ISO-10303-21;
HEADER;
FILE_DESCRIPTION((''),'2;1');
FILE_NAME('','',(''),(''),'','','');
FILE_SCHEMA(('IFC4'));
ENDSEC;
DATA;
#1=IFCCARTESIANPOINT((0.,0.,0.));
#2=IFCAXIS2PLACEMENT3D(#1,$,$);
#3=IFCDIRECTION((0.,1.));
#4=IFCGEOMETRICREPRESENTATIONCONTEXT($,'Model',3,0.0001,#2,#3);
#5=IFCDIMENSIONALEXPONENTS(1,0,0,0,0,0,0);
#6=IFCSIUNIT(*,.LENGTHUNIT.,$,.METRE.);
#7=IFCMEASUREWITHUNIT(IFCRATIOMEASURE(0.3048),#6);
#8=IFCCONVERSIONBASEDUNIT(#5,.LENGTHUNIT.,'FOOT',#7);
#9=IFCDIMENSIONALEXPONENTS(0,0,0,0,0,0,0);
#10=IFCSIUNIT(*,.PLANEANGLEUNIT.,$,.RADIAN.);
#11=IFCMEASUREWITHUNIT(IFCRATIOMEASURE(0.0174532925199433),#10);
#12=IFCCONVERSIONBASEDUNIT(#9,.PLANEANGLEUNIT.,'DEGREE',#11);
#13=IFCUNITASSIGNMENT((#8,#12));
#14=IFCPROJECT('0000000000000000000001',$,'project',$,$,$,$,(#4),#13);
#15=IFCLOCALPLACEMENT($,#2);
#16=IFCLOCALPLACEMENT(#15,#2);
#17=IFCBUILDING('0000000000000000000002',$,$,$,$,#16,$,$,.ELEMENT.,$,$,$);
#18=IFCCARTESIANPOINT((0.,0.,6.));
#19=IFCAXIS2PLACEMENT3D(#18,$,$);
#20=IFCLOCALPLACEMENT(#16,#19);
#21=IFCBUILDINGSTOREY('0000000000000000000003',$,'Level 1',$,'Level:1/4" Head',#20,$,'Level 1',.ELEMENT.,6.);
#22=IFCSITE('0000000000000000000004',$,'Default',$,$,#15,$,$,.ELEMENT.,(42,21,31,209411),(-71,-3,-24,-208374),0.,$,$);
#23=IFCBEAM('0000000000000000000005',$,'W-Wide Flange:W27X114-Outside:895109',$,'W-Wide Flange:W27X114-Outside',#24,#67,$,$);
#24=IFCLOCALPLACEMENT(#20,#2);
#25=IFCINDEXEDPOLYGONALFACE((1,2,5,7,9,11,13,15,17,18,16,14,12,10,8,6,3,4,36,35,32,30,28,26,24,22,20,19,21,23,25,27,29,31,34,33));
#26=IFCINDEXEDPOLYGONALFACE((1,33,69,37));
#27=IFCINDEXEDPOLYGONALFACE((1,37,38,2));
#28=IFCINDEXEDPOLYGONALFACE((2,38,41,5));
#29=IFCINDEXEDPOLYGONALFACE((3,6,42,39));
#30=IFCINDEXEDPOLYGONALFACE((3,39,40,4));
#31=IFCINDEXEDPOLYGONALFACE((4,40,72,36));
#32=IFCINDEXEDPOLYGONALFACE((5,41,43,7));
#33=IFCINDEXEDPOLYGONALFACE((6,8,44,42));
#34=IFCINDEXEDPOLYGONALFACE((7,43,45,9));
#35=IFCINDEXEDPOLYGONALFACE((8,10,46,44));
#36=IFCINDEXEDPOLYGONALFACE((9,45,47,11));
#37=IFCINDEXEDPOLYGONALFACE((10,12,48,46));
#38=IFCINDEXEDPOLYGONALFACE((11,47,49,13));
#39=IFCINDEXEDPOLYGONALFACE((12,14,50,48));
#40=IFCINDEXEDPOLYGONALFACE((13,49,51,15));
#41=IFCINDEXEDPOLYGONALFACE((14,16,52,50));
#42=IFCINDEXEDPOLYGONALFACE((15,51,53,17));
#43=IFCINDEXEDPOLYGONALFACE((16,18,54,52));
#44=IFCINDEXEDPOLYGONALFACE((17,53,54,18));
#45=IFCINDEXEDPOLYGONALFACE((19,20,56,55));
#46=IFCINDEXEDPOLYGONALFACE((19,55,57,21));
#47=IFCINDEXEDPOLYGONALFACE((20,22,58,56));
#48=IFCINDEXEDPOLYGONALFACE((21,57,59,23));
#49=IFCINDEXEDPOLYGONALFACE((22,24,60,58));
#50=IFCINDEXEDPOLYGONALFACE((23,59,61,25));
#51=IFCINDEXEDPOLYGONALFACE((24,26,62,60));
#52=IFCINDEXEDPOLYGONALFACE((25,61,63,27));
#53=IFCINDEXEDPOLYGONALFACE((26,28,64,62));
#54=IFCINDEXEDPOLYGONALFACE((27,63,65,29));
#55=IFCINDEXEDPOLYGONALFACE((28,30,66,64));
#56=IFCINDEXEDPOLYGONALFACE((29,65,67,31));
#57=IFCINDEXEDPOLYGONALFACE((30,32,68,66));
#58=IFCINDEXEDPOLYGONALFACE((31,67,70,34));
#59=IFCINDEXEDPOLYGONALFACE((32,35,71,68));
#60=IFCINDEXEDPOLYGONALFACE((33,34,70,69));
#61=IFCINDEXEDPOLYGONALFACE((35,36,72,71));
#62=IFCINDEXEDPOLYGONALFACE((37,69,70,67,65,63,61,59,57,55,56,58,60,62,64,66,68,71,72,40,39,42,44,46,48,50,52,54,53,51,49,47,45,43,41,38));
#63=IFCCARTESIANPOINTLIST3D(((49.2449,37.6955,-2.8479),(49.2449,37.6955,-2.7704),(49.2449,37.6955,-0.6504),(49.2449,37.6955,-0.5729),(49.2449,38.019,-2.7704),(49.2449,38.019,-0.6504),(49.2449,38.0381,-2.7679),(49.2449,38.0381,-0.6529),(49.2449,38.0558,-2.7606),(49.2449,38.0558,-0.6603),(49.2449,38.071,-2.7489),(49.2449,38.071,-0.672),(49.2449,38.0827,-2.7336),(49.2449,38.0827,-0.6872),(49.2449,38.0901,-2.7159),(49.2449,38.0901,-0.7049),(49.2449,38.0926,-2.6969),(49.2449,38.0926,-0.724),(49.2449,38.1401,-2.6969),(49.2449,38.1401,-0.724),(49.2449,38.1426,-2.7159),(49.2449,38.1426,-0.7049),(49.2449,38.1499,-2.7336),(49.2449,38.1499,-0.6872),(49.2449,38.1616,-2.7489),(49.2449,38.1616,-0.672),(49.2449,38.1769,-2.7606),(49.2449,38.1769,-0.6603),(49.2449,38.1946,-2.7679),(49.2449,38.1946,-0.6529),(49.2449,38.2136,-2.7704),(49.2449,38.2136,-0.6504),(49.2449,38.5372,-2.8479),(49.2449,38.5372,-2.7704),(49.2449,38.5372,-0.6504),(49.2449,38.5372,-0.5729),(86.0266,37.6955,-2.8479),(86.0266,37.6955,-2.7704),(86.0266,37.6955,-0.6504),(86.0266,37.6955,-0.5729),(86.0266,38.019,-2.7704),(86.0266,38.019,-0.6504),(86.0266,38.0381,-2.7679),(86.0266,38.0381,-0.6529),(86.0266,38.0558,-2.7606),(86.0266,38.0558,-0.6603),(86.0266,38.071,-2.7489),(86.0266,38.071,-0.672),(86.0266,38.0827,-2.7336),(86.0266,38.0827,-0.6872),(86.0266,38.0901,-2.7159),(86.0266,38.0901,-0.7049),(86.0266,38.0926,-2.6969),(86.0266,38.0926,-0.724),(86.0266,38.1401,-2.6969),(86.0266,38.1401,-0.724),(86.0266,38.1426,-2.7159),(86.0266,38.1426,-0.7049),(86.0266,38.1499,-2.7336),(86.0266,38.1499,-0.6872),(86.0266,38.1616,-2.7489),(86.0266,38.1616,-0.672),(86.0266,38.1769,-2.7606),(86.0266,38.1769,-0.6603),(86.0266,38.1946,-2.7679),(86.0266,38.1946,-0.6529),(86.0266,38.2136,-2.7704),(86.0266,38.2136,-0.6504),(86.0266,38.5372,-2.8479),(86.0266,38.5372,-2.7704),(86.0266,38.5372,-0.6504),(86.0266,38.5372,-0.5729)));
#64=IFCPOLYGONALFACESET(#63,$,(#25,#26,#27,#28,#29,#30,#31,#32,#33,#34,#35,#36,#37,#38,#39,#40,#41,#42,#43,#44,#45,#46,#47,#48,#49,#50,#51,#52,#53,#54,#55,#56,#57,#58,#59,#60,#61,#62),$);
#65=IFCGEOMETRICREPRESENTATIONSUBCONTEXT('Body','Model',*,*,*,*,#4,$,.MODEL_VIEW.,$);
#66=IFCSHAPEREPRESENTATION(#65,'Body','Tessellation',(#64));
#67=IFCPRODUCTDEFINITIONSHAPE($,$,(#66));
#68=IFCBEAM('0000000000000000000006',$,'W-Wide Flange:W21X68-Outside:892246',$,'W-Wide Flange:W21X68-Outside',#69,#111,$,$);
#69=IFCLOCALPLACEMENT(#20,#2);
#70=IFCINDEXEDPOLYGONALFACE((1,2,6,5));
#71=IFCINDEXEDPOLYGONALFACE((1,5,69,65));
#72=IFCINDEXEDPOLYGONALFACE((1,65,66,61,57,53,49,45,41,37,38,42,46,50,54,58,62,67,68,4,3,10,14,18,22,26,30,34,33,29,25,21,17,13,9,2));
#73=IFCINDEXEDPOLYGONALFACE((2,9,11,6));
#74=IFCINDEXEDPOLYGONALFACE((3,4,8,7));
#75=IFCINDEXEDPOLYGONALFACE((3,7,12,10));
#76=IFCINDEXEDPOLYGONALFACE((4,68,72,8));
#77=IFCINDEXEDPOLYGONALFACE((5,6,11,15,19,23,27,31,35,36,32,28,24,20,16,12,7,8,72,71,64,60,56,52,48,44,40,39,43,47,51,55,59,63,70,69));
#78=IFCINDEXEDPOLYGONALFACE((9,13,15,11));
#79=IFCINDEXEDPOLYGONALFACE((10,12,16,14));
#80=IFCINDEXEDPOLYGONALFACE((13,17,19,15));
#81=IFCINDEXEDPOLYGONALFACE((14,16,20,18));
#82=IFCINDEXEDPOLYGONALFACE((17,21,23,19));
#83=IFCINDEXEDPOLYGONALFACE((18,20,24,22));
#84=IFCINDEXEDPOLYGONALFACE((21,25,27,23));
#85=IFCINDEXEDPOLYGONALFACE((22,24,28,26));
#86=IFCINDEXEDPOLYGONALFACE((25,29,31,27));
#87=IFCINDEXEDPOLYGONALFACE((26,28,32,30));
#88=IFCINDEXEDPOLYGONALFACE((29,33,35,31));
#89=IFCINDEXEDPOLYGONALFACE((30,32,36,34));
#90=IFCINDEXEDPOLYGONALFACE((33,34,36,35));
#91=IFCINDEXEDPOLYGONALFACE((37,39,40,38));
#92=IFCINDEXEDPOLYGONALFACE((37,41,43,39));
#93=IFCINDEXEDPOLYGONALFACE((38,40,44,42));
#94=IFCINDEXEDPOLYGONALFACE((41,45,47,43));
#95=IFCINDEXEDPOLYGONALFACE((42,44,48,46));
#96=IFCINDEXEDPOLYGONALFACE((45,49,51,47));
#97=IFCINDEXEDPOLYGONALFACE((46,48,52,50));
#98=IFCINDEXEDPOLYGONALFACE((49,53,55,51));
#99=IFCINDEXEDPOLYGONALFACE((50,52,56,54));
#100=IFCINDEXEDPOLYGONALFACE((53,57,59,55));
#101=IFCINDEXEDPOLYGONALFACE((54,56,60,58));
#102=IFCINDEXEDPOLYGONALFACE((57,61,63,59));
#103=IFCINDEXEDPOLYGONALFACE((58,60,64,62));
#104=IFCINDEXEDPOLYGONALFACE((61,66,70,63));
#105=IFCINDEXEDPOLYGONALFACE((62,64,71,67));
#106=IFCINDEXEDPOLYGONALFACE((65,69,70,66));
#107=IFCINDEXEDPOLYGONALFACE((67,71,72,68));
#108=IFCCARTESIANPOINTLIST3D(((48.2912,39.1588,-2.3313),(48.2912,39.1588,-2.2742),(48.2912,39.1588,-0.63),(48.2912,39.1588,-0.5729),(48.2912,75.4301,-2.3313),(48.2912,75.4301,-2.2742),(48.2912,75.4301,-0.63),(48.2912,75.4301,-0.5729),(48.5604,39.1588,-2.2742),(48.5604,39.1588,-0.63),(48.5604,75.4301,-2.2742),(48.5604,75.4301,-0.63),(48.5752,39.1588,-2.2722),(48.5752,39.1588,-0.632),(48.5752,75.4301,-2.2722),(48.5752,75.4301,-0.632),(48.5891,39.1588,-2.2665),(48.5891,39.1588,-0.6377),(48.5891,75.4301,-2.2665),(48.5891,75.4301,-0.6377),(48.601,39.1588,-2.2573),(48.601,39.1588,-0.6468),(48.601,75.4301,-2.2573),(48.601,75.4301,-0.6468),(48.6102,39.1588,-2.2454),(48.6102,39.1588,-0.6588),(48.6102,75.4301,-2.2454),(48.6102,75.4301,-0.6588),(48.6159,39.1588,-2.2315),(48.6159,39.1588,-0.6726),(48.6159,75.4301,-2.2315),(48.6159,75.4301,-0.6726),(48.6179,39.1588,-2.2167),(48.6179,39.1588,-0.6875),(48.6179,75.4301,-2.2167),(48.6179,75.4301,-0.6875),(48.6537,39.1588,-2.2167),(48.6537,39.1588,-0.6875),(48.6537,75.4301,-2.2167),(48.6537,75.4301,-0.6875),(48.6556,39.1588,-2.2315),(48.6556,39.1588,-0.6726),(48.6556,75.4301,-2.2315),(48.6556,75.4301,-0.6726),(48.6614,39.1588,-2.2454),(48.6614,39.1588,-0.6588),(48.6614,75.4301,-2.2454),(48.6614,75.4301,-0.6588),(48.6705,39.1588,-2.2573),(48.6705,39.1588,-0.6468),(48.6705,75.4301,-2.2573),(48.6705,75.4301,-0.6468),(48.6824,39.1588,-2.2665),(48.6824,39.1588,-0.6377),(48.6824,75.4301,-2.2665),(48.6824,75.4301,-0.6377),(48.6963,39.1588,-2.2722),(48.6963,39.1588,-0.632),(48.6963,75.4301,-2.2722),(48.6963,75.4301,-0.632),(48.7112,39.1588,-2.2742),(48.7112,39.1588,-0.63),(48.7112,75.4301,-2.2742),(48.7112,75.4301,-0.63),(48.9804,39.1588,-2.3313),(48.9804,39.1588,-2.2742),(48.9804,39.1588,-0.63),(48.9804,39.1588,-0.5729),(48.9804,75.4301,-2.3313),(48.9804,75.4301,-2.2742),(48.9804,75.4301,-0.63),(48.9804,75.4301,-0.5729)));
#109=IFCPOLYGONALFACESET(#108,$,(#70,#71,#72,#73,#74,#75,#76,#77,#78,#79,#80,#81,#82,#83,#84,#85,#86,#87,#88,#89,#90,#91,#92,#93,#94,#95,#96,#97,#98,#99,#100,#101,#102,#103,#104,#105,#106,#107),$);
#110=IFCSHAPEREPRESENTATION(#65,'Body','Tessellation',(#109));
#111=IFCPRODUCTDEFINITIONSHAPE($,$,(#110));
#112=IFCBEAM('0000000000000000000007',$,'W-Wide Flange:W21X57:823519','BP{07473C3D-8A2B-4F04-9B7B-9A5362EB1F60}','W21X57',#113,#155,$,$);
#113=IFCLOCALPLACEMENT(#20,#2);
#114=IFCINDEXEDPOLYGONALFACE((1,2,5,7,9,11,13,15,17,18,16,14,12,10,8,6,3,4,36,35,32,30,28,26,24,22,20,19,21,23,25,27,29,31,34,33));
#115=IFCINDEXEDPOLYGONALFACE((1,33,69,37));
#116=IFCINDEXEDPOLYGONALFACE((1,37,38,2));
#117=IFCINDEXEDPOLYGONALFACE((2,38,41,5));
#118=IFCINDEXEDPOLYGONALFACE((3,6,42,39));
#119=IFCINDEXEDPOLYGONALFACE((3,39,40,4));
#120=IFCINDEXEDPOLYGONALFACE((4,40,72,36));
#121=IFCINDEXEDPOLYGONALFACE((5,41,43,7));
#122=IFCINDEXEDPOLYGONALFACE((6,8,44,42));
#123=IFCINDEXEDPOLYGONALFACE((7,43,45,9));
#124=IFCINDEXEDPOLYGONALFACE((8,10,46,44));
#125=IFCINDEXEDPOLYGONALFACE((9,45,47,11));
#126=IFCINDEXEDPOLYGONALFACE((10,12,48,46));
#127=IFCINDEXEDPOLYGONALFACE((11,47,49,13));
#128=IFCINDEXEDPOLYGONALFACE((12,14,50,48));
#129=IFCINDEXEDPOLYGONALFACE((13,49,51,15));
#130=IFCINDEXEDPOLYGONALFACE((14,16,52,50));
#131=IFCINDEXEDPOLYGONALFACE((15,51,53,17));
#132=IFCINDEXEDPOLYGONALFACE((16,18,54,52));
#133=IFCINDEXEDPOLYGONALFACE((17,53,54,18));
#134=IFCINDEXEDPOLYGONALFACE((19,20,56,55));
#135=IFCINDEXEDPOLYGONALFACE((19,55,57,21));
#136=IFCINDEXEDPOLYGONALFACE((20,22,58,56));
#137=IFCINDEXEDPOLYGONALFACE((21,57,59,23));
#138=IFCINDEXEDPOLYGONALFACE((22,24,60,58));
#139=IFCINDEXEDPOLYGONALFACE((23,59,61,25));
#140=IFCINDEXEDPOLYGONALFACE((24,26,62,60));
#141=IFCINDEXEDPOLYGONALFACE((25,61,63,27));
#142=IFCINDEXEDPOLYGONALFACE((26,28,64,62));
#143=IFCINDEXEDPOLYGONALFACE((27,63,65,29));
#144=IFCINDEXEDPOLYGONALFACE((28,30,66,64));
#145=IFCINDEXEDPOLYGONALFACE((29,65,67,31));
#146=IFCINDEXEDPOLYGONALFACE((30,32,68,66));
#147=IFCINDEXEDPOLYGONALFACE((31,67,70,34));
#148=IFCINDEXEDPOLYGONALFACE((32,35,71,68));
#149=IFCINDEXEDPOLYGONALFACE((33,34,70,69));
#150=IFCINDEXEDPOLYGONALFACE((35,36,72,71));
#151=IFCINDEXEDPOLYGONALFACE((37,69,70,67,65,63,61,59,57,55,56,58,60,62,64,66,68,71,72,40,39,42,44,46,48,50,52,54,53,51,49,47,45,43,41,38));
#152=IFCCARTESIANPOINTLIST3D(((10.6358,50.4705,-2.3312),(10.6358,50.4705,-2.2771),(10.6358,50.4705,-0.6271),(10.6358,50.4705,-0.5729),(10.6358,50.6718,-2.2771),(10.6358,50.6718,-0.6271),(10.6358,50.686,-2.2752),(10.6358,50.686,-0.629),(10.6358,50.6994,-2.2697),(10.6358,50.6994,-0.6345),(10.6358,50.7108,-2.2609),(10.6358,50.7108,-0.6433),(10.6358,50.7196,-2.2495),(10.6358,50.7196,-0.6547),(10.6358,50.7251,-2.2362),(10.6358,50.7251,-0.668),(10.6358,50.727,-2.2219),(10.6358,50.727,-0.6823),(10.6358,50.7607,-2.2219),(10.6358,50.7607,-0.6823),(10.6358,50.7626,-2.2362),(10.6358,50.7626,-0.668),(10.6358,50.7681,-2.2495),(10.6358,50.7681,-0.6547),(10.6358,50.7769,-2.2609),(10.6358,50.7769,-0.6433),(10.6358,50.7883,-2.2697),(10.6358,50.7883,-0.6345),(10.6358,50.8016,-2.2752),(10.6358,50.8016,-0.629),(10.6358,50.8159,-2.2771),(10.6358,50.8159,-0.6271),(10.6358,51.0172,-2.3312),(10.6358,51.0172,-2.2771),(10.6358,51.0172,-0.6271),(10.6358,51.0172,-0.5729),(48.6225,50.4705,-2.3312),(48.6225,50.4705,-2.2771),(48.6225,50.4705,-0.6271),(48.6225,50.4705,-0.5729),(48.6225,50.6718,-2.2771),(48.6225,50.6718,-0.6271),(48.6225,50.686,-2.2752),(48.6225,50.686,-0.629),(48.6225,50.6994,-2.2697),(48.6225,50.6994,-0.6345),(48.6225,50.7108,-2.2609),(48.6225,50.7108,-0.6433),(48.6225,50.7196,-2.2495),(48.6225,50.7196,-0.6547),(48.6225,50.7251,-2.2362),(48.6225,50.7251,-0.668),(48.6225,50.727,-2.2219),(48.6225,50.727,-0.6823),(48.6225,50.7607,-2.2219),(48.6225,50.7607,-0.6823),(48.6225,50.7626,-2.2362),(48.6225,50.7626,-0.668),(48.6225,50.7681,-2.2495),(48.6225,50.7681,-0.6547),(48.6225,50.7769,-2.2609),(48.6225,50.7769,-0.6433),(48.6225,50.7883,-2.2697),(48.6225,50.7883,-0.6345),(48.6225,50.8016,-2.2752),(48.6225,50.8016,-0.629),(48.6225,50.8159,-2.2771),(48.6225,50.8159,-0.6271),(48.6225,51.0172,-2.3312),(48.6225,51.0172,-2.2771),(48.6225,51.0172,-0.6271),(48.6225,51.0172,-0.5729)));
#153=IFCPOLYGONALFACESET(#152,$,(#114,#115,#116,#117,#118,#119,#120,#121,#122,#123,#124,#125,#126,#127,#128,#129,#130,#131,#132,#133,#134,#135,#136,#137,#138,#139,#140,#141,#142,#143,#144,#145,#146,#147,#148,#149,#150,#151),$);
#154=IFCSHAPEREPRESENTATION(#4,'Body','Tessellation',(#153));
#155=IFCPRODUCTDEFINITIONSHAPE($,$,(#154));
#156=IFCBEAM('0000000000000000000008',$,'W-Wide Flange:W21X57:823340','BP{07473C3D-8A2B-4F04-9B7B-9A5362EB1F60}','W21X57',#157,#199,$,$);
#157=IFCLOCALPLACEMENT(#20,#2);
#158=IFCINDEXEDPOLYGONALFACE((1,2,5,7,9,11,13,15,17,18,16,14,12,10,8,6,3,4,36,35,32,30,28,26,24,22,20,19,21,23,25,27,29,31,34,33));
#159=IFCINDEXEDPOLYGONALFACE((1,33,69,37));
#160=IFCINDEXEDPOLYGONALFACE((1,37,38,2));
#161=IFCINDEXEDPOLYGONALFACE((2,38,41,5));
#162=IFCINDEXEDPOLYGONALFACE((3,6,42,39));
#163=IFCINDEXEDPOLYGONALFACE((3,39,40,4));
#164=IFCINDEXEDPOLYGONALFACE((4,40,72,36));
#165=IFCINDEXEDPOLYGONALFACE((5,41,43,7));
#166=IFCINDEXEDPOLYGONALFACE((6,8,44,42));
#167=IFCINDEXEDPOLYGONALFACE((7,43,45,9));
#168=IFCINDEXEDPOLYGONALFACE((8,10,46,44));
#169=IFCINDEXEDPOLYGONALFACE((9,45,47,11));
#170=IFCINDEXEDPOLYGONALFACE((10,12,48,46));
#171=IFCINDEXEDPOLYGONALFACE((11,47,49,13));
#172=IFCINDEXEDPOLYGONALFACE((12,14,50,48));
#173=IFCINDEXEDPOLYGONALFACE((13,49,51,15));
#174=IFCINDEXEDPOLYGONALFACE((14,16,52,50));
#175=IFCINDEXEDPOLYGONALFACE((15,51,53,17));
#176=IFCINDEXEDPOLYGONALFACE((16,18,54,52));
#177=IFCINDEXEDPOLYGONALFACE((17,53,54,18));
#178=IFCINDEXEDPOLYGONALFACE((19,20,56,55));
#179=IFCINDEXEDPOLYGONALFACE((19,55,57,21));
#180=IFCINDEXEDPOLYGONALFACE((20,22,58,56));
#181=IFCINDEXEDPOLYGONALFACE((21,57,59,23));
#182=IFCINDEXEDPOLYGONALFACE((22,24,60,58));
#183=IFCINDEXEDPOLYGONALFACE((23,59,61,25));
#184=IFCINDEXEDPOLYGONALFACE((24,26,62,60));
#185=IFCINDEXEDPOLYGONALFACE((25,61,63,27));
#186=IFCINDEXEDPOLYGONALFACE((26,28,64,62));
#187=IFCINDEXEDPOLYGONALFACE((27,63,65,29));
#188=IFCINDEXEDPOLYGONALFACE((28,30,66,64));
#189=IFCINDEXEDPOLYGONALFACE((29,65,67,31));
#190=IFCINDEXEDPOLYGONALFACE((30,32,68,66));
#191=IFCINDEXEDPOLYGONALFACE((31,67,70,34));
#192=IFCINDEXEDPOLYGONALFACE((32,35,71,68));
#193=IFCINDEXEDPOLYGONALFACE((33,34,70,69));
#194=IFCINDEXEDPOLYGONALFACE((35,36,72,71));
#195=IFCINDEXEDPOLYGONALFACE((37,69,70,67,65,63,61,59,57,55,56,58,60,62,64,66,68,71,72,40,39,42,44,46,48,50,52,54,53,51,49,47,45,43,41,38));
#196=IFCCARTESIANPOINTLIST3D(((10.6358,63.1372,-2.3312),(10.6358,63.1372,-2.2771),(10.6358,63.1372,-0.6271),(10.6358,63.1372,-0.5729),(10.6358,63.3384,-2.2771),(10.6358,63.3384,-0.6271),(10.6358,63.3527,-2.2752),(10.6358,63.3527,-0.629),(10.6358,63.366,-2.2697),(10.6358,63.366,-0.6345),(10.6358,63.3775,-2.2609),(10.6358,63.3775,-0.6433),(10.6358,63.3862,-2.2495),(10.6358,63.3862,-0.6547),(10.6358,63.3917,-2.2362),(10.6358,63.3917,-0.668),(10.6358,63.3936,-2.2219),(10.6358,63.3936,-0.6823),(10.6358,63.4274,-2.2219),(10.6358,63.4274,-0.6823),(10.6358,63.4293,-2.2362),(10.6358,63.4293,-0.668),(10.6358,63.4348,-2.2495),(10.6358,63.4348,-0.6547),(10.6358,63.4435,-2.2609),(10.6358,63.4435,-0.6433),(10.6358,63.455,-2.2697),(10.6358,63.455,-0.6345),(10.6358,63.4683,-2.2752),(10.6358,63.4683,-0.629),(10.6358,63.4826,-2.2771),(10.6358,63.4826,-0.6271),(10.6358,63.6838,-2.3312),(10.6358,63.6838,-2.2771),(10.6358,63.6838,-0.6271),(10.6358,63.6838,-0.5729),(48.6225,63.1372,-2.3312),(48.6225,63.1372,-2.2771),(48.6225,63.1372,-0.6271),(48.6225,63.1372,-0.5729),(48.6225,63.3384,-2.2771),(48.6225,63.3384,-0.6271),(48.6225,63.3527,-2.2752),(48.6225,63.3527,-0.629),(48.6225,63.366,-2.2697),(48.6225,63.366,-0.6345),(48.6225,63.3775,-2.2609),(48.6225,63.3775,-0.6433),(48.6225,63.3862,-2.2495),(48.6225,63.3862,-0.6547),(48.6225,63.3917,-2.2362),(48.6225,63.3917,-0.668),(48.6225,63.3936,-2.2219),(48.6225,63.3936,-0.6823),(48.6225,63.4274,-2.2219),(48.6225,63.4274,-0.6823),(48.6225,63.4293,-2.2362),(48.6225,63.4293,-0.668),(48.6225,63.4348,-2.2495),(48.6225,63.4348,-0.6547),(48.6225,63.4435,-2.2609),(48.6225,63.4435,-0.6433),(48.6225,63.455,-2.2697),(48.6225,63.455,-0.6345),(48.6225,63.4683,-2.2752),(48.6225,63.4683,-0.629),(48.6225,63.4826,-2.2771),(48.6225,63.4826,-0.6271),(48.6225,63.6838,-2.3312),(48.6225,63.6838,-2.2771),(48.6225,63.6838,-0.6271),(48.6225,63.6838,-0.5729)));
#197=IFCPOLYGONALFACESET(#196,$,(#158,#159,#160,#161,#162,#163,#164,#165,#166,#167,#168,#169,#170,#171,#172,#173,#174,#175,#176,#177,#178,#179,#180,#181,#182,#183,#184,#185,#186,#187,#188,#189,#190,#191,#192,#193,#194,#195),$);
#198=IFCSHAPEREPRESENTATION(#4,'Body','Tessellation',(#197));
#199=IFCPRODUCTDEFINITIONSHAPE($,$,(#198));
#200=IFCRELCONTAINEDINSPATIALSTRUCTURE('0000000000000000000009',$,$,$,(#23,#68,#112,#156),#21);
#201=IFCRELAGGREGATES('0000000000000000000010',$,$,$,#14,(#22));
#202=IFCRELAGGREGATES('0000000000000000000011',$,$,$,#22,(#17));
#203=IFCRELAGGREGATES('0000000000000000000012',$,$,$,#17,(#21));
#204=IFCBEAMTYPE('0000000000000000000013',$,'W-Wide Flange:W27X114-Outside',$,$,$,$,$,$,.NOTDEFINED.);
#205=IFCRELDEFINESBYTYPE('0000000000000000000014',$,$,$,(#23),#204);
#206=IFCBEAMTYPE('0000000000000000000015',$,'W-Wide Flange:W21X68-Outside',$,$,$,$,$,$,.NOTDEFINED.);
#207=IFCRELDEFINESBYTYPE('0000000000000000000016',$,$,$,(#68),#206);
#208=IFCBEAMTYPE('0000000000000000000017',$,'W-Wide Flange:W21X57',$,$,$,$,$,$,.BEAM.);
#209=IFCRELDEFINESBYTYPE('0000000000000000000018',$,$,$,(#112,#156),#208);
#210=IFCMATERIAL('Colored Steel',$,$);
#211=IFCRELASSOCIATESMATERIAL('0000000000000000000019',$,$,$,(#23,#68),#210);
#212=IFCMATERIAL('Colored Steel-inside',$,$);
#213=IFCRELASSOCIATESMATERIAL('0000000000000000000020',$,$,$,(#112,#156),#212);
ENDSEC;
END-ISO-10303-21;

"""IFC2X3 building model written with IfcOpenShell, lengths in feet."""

from ifc_helpers import new_model, entity, si_unit, converted_unit, direction, frame, frame_2d, origin, origin_2d, place, context, subcontext, project, spatial, i_section, extrude, material, type_object, element, save


model = new_model("IFC2X3")

# Units and contexts
model_context = context("Model", 3, precision=0.0001, world=origin(), true_north=direction((0.0, 1.0)))
body_context = subcontext(model_context, "Body", "Model", "MODEL_VIEW")
ifc_project = project(units=[converted_unit("LENGTHUNIT", "FOOT", entity("IfcRatioMeasure", 0.3048), si_unit("LENGTHUNIT", "METRE"), dimensions=[1, 0, 0, 0, 0, 0, 0]), converted_unit("PLANEANGLEUNIT", "DEGREE", entity("IfcRatioMeasure", 0.0174532925199433), si_unit("PLANEANGLEUNIT", "RADIAN"), dimensions=[0, 0, 0, 0, 0, 0, 0])], contexts=[model_context])

# Site, building, storey
site_placement = place(None, origin())
site = spatial("IfcSite", under=ifc_project, at=site_placement, Name="Default", CompositionType="ELEMENT", RefLatitude=(42, 21, 31, 209411), RefLongitude=(-71, -3, -24, -208374), RefElevation=0.0)
building_placement = place(site_placement, origin())
building = spatial("IfcBuilding", under=site, at=building_placement, CompositionType="ELEMENT")
storey_placement = place(building_placement, frame((0.0, 0.0, 6.0)))
storey = spatial("IfcBuildingStorey", under=building, at=storey_placement, Name="Level 1", ObjectType="Level:1/4\" Head", LongName="Level 1", CompositionType="ELEMENT", Elevation=6.0)

# Shared definitions
ifc_material_1 = material(Name="Colored Steel-inside")

# Beams
ifc_material_2 = material(Name="Colored Steel")
beam_type_1 = type_object("IfcBeamType", Name="W-Wide Flange:W27X114-Outside", PredefinedType="NOTDEFINED")
beam_1_placement = place(storey_placement, frame((48.6358, 38.1163, 0.0)))
element("IfcBeam", 1, at=beam_1_placement, inside=storey, type_object=beam_type_1, material=ifc_material_2, Name="W-Wide Flange:W27X114-Outside:895109", ObjectType="W-Wide Flange:W27X114-Outside", context=body_context, shape_type="SweptSolid", body=[
    extrude(i_section(OverallWidth=0.8417, OverallDepth=2.275, WebThickness=0.0475, FlangeThickness=0.0775, FilletRadius=0.0735, at=frame_2d((0.0, 0.0), x_axis=(0.0, 1.0))), frame((0.6092, 0.0, -1.7104), z_axis=(1.0, 0.0, 0.0), x_axis=(0.0, 0.0, -1.0)), (0.0, 0.0, 1.0), 36.7817),
])
beam_type_2 = type_object("IfcBeamType", Name="W-Wide Flange:W21X68-Outside", PredefinedType="NOTDEFINED")
beam_2_placement = place(storey_placement, frame((48.6358, 76.0968, 0.0), z_axis=(0.0, 0.0, 1.0), x_axis=(0.0, -1.0, 0.0)))
element("IfcBeam", 2, at=beam_2_placement, inside=storey, type_object=beam_type_2, material=ifc_material_2, Name="W-Wide Flange:W21X68-Outside:892246", ObjectType="W-Wide Flange:W21X68-Outside", context=body_context, shape_type="SweptSolid", body=[
    extrude(i_section(OverallWidth=0.6892, OverallDepth=1.7583, WebThickness=0.0358, FlangeThickness=0.0571, FilletRadius=0.0575, at=frame_2d((0.0, 0.0), x_axis=(0.0, 1.0))), frame((0.6667, 0.0, -1.4521), z_axis=(1.0, 0.0, 0.0), x_axis=(0.0, 0.0, -1.0)), (0.0, 0.0, 1.0), 36.2713),
])
beam_type_3 = type_object("IfcBeamType", Name="W-Wide Flange:W21X57", PredefinedType="BEAM")
for number, where, z_axis, x_axis, name in (
    (3, (10.6358, 50.7438, -1.4521), (-1.0, 0.0, 0.0), (0.0, -1.0, 0.0), "W-Wide Flange:W21X57:823519"),
    (4, (10.6358, 63.4105, -1.4521), (-1.0, 0.0, 0.0), (0.0, -1.0, 0.0), "W-Wide Flange:W21X57:823340"),
):
    element("IfcBeam", number, at=place(storey_placement, frame(where, z_axis=z_axis, x_axis=x_axis)), inside=storey, type_object=beam_type_3, material=ifc_material_1, Name=name, Description="BP{07473C3D-8A2B-4F04-9B7B-9A5362EB1F60}", ObjectType="W21X57", context=model_context, shape_type="SweptSolid", body=[
        extrude(i_section(OverallWidth=0.5467, OverallDepth=1.7583, WebThickness=0.0338, FlangeThickness=0.0542, FilletRadius=0.0552, at=origin_2d()), origin(), (0.0, 0.0, -1.0), 37.9867),
    ])

save(model, "model.ifc")
